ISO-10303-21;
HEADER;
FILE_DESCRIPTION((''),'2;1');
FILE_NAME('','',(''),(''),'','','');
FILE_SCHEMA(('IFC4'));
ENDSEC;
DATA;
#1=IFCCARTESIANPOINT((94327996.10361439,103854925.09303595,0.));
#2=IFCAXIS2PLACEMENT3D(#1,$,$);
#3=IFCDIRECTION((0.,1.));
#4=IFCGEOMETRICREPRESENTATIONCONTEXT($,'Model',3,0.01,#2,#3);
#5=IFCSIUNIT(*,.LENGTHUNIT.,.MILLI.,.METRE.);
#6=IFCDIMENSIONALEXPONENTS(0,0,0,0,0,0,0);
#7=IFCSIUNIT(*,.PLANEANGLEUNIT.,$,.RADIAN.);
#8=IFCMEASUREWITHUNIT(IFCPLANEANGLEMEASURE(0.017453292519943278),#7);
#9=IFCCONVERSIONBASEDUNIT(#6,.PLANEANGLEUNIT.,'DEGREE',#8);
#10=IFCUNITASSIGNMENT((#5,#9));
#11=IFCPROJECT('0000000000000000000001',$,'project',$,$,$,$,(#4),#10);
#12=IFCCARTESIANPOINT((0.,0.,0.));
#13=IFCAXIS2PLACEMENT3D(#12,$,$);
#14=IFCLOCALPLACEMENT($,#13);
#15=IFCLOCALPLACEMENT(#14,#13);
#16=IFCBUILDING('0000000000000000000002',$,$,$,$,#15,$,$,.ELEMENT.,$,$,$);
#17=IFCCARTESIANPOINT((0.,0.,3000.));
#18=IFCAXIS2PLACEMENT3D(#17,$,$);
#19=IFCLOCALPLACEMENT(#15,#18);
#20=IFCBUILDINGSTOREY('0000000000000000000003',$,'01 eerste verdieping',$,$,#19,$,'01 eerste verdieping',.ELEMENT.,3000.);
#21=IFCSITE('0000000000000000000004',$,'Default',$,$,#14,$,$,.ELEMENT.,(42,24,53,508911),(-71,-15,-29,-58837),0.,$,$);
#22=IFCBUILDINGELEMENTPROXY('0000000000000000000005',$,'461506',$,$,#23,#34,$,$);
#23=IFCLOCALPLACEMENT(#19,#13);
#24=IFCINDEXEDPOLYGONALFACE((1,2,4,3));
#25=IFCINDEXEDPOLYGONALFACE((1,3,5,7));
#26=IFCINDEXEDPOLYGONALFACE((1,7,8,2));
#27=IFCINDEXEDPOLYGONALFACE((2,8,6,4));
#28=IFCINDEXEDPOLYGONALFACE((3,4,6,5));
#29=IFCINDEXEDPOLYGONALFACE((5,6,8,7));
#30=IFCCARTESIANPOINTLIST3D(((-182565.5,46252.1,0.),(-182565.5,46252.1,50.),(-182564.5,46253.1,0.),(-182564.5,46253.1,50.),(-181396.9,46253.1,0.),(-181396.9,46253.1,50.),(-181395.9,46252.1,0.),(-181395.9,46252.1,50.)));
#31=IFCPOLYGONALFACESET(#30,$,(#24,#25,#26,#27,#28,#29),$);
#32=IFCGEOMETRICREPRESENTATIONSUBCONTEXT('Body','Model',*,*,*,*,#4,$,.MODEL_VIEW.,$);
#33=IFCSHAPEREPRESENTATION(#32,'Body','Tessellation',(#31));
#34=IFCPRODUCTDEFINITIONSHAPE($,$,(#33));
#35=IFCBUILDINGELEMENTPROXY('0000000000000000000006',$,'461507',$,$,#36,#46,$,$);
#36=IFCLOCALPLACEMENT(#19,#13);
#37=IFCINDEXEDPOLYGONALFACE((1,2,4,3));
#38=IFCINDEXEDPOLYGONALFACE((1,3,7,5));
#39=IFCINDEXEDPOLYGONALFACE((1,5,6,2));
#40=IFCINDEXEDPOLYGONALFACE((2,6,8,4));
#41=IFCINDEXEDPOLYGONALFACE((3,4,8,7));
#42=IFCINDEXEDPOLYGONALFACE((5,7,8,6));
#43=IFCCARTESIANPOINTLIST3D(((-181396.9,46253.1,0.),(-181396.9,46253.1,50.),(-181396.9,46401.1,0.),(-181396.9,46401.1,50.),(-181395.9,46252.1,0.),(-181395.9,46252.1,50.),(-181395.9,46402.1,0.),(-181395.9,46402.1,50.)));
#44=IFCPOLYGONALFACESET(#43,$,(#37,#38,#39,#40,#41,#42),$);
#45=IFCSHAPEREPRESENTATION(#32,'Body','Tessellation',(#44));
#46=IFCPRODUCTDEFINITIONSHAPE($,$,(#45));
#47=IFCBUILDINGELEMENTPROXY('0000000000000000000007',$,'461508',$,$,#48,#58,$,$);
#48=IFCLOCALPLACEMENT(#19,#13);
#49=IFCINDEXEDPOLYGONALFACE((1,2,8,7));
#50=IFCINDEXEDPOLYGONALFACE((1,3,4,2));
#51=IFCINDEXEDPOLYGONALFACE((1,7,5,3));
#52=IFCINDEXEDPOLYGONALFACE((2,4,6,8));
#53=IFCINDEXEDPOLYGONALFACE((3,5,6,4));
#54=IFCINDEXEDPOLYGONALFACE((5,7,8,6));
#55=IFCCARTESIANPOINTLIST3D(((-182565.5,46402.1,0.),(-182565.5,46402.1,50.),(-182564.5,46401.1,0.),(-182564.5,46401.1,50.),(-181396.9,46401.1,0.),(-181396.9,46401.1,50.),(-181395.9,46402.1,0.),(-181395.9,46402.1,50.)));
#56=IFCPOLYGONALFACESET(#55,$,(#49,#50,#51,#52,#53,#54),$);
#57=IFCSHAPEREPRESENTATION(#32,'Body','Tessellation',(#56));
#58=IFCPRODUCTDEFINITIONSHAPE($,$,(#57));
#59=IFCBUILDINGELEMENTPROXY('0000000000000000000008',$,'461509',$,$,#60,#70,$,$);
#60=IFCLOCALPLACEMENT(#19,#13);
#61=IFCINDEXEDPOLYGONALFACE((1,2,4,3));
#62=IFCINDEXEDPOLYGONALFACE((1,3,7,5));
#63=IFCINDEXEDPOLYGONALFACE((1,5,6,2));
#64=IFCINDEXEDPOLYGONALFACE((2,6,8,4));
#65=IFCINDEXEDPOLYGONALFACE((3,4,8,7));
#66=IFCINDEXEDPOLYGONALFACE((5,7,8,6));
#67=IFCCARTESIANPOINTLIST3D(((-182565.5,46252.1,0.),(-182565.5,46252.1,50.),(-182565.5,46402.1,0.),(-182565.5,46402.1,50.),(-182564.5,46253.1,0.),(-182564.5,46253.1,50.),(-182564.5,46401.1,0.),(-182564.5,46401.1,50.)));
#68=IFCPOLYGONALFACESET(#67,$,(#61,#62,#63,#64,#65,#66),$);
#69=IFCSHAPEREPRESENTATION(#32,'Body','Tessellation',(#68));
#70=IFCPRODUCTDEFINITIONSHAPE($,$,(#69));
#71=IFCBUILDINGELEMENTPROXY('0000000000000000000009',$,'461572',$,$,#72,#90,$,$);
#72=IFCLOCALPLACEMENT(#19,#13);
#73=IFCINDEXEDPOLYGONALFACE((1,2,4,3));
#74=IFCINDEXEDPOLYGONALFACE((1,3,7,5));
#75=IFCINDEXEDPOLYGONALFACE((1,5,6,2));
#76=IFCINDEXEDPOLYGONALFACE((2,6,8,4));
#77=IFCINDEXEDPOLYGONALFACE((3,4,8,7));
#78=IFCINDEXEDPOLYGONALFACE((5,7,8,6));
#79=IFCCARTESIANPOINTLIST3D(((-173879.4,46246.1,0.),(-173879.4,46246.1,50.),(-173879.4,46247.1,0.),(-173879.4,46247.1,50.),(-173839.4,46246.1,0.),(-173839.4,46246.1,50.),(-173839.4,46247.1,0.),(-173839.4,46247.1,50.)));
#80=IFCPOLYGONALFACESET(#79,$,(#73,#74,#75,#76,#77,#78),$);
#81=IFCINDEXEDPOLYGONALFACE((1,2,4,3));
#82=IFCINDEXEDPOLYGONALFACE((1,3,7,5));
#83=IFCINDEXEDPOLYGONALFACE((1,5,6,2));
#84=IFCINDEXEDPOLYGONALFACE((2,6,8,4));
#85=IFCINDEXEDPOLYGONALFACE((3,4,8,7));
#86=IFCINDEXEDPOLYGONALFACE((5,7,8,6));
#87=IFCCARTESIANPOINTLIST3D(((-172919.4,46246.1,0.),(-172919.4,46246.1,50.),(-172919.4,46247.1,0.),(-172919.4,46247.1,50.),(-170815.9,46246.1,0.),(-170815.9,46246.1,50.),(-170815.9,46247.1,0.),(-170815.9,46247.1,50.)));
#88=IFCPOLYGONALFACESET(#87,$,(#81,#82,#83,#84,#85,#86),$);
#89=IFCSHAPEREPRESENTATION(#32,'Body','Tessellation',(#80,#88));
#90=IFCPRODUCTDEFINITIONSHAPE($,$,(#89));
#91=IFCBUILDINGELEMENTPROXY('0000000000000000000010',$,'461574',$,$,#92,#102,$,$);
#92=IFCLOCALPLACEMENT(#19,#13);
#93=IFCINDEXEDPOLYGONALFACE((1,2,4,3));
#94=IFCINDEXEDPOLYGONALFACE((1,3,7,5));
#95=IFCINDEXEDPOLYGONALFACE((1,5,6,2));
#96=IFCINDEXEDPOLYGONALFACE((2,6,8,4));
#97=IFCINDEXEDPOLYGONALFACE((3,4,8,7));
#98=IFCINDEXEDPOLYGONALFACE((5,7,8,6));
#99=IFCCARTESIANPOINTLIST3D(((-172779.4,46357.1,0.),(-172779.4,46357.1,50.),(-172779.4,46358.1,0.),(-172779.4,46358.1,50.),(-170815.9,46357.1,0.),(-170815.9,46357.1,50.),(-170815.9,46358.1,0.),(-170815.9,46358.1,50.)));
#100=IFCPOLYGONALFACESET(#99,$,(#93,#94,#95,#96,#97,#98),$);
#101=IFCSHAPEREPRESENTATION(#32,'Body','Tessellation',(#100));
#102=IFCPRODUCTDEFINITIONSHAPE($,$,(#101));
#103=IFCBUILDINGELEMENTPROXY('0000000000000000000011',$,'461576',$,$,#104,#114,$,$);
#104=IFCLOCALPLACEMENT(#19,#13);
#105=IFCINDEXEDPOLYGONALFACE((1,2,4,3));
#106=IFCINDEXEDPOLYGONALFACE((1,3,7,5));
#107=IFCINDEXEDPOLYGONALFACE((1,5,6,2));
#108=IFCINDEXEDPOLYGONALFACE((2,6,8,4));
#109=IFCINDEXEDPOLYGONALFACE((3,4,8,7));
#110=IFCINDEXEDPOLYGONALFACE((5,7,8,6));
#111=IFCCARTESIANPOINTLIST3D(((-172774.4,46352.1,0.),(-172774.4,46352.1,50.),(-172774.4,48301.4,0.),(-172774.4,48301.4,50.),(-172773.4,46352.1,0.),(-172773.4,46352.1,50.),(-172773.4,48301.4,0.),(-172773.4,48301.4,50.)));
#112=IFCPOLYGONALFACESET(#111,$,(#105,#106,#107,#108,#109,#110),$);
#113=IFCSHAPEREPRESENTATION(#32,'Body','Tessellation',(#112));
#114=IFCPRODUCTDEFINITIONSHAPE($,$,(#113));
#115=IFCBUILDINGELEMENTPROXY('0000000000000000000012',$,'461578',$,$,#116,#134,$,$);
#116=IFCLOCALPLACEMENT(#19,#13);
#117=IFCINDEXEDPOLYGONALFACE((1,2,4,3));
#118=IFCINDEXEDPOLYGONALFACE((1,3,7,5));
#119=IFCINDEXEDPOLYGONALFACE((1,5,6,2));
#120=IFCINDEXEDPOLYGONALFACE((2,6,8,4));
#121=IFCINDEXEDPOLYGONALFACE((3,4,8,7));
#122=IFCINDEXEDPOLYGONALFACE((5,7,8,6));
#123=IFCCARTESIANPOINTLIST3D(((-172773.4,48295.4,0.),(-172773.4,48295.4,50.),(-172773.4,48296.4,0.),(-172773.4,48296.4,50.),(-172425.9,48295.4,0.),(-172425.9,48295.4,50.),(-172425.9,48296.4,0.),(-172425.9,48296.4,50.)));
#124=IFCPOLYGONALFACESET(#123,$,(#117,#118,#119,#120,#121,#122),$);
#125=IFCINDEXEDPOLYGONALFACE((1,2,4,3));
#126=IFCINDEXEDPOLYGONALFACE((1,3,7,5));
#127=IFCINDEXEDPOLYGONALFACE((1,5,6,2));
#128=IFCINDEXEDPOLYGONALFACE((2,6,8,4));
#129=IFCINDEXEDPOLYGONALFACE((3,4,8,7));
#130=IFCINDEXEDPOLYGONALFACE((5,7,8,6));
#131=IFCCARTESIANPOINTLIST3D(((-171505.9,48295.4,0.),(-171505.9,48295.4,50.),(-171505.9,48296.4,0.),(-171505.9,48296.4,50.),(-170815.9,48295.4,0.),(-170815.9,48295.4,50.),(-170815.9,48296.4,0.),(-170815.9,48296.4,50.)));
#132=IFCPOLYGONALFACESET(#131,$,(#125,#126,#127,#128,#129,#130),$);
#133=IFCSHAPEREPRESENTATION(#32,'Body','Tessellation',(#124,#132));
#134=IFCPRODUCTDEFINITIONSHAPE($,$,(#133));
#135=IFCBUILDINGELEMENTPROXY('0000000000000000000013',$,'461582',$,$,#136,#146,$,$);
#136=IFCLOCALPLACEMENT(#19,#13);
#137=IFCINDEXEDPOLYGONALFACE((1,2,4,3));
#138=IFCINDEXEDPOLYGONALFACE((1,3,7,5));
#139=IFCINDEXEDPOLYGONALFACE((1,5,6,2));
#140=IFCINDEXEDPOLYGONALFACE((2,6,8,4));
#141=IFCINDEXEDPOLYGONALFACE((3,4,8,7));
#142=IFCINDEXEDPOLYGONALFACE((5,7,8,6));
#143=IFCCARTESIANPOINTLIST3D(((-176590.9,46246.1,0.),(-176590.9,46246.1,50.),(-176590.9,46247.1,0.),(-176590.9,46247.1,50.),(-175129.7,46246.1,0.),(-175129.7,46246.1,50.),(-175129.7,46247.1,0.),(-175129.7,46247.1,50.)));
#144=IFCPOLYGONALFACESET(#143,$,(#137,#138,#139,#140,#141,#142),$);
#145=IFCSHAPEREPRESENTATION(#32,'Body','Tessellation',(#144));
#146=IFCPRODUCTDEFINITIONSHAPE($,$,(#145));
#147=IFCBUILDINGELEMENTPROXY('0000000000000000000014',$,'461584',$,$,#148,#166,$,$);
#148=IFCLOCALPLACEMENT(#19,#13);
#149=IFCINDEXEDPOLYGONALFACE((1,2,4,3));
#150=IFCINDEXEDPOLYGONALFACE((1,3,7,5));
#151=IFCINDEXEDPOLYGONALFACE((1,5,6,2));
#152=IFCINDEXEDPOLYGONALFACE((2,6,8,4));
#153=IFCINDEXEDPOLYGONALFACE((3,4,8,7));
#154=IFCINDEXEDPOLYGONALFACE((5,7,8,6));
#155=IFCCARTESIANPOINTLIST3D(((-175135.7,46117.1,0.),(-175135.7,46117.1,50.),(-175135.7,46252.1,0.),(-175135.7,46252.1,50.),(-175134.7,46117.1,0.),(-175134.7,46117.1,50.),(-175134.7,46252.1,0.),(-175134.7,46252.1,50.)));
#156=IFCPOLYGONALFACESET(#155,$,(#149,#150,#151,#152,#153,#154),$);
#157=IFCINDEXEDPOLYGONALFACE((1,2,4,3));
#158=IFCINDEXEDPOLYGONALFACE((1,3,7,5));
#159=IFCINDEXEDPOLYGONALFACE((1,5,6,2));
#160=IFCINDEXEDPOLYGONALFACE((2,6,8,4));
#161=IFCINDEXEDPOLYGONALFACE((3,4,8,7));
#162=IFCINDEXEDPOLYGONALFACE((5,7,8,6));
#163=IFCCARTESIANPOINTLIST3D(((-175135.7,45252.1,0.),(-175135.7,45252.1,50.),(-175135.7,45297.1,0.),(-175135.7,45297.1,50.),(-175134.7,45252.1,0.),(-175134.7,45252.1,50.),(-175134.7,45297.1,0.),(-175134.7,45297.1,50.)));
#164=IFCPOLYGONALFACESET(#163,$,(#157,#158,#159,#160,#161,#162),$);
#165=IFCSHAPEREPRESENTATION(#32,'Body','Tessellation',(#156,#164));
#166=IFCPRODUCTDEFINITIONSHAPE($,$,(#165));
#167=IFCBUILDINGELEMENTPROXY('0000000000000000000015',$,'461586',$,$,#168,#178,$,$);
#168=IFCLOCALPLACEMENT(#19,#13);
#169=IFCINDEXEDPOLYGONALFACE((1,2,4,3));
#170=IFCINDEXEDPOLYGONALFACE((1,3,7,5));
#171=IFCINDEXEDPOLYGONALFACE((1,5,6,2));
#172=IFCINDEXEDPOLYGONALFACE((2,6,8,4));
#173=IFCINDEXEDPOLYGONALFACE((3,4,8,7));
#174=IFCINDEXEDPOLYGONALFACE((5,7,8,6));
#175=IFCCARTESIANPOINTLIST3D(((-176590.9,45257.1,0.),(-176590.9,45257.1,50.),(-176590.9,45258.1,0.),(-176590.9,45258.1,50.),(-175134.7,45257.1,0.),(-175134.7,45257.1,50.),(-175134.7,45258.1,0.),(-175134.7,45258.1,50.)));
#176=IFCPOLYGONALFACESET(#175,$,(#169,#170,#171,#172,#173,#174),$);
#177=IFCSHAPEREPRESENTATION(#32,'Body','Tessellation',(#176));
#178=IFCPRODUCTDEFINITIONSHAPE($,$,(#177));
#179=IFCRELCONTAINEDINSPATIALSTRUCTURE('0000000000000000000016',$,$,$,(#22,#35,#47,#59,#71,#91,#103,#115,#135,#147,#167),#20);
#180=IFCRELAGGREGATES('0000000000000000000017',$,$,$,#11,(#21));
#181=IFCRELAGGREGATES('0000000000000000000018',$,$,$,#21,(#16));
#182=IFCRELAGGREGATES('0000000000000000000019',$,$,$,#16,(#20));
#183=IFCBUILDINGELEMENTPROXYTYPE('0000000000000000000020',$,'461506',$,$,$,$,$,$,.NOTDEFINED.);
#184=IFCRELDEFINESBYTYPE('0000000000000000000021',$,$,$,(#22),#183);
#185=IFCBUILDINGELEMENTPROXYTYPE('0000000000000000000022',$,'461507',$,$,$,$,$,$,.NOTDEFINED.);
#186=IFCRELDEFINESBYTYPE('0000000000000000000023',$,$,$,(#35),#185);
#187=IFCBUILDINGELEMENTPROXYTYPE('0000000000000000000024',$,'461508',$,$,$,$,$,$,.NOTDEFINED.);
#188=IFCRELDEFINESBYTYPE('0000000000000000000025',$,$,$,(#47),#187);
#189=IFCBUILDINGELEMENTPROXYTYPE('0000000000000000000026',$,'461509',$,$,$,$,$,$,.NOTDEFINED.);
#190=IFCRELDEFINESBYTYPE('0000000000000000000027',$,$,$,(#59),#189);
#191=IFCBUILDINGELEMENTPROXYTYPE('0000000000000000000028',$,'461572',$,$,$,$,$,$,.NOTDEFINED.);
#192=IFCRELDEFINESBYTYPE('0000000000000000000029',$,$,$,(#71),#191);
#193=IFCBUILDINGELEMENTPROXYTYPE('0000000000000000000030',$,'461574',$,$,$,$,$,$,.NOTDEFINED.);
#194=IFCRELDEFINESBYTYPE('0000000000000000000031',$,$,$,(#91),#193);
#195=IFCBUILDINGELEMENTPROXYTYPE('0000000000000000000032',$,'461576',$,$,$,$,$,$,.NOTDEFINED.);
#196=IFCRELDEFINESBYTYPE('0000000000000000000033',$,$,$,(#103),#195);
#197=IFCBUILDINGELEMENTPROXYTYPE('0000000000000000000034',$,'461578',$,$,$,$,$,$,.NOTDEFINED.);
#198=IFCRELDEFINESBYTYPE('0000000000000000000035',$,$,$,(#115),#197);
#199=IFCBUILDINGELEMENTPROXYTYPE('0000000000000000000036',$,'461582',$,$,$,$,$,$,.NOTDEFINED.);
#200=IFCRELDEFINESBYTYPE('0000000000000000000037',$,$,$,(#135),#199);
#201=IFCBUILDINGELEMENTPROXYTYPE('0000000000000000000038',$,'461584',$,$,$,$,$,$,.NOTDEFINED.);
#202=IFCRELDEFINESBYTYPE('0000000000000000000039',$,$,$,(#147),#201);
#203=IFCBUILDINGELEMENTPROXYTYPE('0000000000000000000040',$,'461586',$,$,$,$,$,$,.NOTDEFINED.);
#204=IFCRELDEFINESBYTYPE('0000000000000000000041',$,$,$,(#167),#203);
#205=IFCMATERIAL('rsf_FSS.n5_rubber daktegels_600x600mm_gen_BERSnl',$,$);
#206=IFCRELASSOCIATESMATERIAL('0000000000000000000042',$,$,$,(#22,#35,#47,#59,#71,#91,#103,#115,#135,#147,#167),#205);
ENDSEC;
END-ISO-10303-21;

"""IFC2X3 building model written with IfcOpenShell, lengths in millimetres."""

from ifc_helpers import new_model, entity, si_unit, converted_unit, direction, frame, frame_2d, origin, origin_2d_with_axis, place, context, subcontext, project, spatial, polyline, rectangle, outline, extrude, material, type_object, element, save


model = new_model("IFC2X3")

# Units and contexts
model_context = context("Model", 3, precision=0.01, world=frame((94327996.10361439, 103854925.09303595, 0.0)), true_north=direction((0.0, 1.0)))
body_context = subcontext(model_context, "Body", "Model", "MODEL_VIEW")
ifc_project = project(units=[si_unit("LENGTHUNIT", "METRE", prefix="MILLI"), converted_unit("PLANEANGLEUNIT", "DEGREE", entity("IfcPlaneAngleMeasure", 0.017453292519943278), si_unit("PLANEANGLEUNIT", "RADIAN"), dimensions=[0, 0, 0, 0, 0, 0, 0])], contexts=[model_context])

# Site, building, storey
site_placement = place(None, origin())
site = spatial("IfcSite", under=ifc_project, at=site_placement, Name="Default", CompositionType="ELEMENT", RefLatitude=(42, 24, 53, 508911), RefLongitude=(-71, -15, -29, -58837), RefElevation=0.0)
building_placement = place(site_placement, origin())
building = spatial("IfcBuilding", under=site, at=building_placement, CompositionType="ELEMENT")
storey_placement = place(building_placement, frame((0.0, 0.0, 3000.0)))
storey = spatial("IfcBuildingStorey", under=building, at=storey_placement, Name="01 eerste verdieping", LongName="01 eerste verdieping", CompositionType="ELEMENT", Elevation=3000.0)

# Building element proxies
ifc_material = material(Name="rsf_FSS.n5_rubber daktegels_600x600mm_gen_BERSnl")
building_element_proxy_type_1 = type_object("IfcBuildingElementProxyType", Name="461506", PredefinedType="NOTDEFINED")
proxy_1_placement = place(storey_placement, origin())
element("IfcBuildingElementProxy", 1, at=proxy_1_placement, inside=storey, type_object=building_element_proxy_type_1, material=ifc_material, Name="461506", context=body_context, shape_type="SweptSolid", body=[
    extrude(outline(polyline([(-583.8, -0.5), (583.8, -0.5), (584.8, 0.5), (-584.8, 0.5), (-583.8, -0.5)])), frame((-181980.7, 46252.6, 0.0), z_axis=(0.0, 0.0, 1.0), x_axis=(-1.0, 0.0, 0.0)), (0.0, 0.0, 1.0), 50.0),
])
building_element_proxy_type_2 = type_object("IfcBuildingElementProxyType", Name="461507", PredefinedType="NOTDEFINED")
proxy_2_placement = place(storey_placement, origin())
element("IfcBuildingElementProxy", 2, at=proxy_2_placement, inside=storey, type_object=building_element_proxy_type_2, material=ifc_material, Name="461507", context=body_context, shape_type="SweptSolid", body=[
    extrude(outline(polyline([(-74.0, -0.5), (74.0, -0.5), (75.0, 0.5), (-75.0, 0.5), (-74.0, -0.5)])), frame((-181396.4, 46327.1, 0.0), z_axis=(0.0, 0.0, 1.0), x_axis=(0.0, -1.0, 0.0)), (0.0, 0.0, 1.0), 50.0),
])
building_element_proxy_type_3 = type_object("IfcBuildingElementProxyType", Name="461508", PredefinedType="NOTDEFINED")
proxy_3_placement = place(storey_placement, origin())
element("IfcBuildingElementProxy", 3, at=proxy_3_placement, inside=storey, type_object=building_element_proxy_type_3, material=ifc_material, Name="461508", context=body_context, shape_type="SweptSolid", body=[
    extrude(outline(polyline([(-583.8, -0.5), (583.8, -0.5), (584.8, 0.5), (-584.8, 0.5), (-583.8, -0.5)])), frame((-181980.7, 46401.6, 0.0)), (0.0, 0.0, 1.0), 50.0),
])
building_element_proxy_type_4 = type_object("IfcBuildingElementProxyType", Name="461509", PredefinedType="NOTDEFINED")
proxy_4_placement = place(storey_placement, origin())
element("IfcBuildingElementProxy", 4, at=proxy_4_placement, inside=storey, type_object=building_element_proxy_type_4, material=ifc_material, Name="461509", context=body_context, shape_type="SweptSolid", body=[
    extrude(outline(polyline([(-74.0, -0.5), (74.0, -0.5), (75.0, 0.5), (-75.0, 0.5), (-74.0, -0.5)])), frame((-182565.0, 46327.1, 0.0), z_axis=(0.0, 0.0, 1.0), x_axis=(0.0, 1.0, 0.0)), (0.0, 0.0, 1.0), 50.0),
])
building_element_proxy_type_5 = type_object("IfcBuildingElementProxyType", Name="461572", PredefinedType="NOTDEFINED")
proxy_5_placement = place(storey_placement, origin())
element("IfcBuildingElementProxy", 5, at=proxy_5_placement, inside=storey, type_object=building_element_proxy_type_5, material=ifc_material, Name="461572", context=body_context, shape_type="SweptSolid", body=[
    extrude(rectangle(XDim=40.0, YDim=1.0, at=origin_2d_with_axis()), frame((-173859.4, 46246.6, 0.0)), (0.0, 0.0, 1.0), 50.0),
    extrude(rectangle(XDim=2103.5, YDim=1.0, at=frame_2d((0.0, 0.0), x_axis=(1.0, 0.0))), frame((-171867.6, 46246.6, 0.0)), (0.0, 0.0, 1.0), 50.0),
])
building_element_proxy_type_6 = type_object("IfcBuildingElementProxyType", Name="461574", PredefinedType="NOTDEFINED")
proxy_6_placement = place(storey_placement, origin())
element("IfcBuildingElementProxy", 6, at=proxy_6_placement, inside=storey, type_object=building_element_proxy_type_6, material=ifc_material, Name="461574", context=body_context, shape_type="SweptSolid", body=[
    extrude(rectangle(XDim=1963.5, YDim=1.0, at=frame_2d((0.0, 0.0), x_axis=(1.0, 0.0))), frame((-171797.6, 46357.6, 0.0), z_axis=(0.0, 0.0, 1.0), x_axis=(-1.0, 0.0, 0.0)), (0.0, 0.0, 1.0), 50.0),
])
building_element_proxy_type_7 = type_object("IfcBuildingElementProxyType", Name="461576", PredefinedType="NOTDEFINED")
proxy_7_placement = place(storey_placement, origin())
element("IfcBuildingElementProxy", 7, at=proxy_7_placement, inside=storey, type_object=building_element_proxy_type_7, material=ifc_material, Name="461576", context=body_context, shape_type="SweptSolid", body=[
    extrude(rectangle(XDim=1949.4, YDim=1.0, at=frame_2d((0.0, 0.0), x_axis=(1.0, 0.0))), frame((-172773.9, 47326.7, 0.0), z_axis=(0.0, 0.0, 1.0), x_axis=(0.0, 1.0, 0.0)), (0.0, 0.0, 1.0), 50.0),
])
building_element_proxy_type_8 = type_object("IfcBuildingElementProxyType", Name="461578", PredefinedType="NOTDEFINED")
proxy_8_placement = place(storey_placement, origin())
element("IfcBuildingElementProxy", 8, at=proxy_8_placement, inside=storey, type_object=building_element_proxy_type_8, material=ifc_material, Name="461578", context=body_context, shape_type="SweptSolid", body=[
    extrude(rectangle(XDim=347.5, YDim=1.0, at=origin_2d_with_axis()), frame((-172599.6, 48295.9, 0.0)), (0.0, 0.0, 1.0), 50.0),
    extrude(rectangle(XDim=690.0, YDim=1.0, at=origin_2d_with_axis()), frame((-171160.9, 48295.9, 0.0)), (0.0, 0.0, 1.0), 50.0),
])
building_element_proxy_type_9 = type_object("IfcBuildingElementProxyType", Name="461582", PredefinedType="NOTDEFINED")
proxy_9_placement = place(storey_placement, origin())
element("IfcBuildingElementProxy", 9, at=proxy_9_placement, inside=storey, type_object=building_element_proxy_type_9, material=ifc_material, Name="461582", context=body_context, shape_type="SweptSolid", body=[
    extrude(rectangle(XDim=1461.2, YDim=1.0, at=frame_2d((0.0, 0.0), x_axis=(1.0, 0.0))), frame((-175860.3, 46246.6, 0.0)), (0.0, 0.0, 1.0), 50.0),
])
building_element_proxy_type_10 = type_object("IfcBuildingElementProxyType", Name="461584", PredefinedType="NOTDEFINED")
proxy_10_placement = place(storey_placement, origin())
element("IfcBuildingElementProxy", 10, at=proxy_10_placement, inside=storey, type_object=building_element_proxy_type_10, material=ifc_material, Name="461584", context=body_context, shape_type="SweptSolid", body=[
    extrude(rectangle(XDim=135.0, YDim=1.0, at=frame_2d((0.0, 0.0), x_axis=(1.0, 0.0))), frame((-175135.2, 46184.6, 0.0), z_axis=(0.0, 0.0, 1.0), x_axis=(0.0, -1.0, 0.0)), (0.0, 0.0, 1.0), 50.0),
    extrude(rectangle(XDim=45.0, YDim=1.0, at=frame_2d((0.0, 0.0), x_axis=(1.0, 0.0))), frame((-175135.2, 45274.6, 0.0), z_axis=(0.0, 0.0, 1.0), x_axis=(0.0, -1.0, 0.0)), (0.0, 0.0, 1.0), 50.0),
])
building_element_proxy_type_11 = type_object("IfcBuildingElementProxyType", Name="461586", PredefinedType="NOTDEFINED")
proxy_11_placement = place(storey_placement, origin())
element("IfcBuildingElementProxy", 11, at=proxy_11_placement, inside=storey, type_object=building_element_proxy_type_11, material=ifc_material, Name="461586", context=body_context, shape_type="SweptSolid", body=[
    extrude(rectangle(XDim=1456.2, YDim=1.0, at=frame_2d((0.0, 0.0), x_axis=(1.0, 0.0))), frame((-175862.8, 45257.6, 0.0), z_axis=(0.0, 0.0, 1.0), x_axis=(-1.0, 0.0, 0.0)), (0.0, 0.0, 1.0), 50.0),
])

save(model, "model.ifc")
